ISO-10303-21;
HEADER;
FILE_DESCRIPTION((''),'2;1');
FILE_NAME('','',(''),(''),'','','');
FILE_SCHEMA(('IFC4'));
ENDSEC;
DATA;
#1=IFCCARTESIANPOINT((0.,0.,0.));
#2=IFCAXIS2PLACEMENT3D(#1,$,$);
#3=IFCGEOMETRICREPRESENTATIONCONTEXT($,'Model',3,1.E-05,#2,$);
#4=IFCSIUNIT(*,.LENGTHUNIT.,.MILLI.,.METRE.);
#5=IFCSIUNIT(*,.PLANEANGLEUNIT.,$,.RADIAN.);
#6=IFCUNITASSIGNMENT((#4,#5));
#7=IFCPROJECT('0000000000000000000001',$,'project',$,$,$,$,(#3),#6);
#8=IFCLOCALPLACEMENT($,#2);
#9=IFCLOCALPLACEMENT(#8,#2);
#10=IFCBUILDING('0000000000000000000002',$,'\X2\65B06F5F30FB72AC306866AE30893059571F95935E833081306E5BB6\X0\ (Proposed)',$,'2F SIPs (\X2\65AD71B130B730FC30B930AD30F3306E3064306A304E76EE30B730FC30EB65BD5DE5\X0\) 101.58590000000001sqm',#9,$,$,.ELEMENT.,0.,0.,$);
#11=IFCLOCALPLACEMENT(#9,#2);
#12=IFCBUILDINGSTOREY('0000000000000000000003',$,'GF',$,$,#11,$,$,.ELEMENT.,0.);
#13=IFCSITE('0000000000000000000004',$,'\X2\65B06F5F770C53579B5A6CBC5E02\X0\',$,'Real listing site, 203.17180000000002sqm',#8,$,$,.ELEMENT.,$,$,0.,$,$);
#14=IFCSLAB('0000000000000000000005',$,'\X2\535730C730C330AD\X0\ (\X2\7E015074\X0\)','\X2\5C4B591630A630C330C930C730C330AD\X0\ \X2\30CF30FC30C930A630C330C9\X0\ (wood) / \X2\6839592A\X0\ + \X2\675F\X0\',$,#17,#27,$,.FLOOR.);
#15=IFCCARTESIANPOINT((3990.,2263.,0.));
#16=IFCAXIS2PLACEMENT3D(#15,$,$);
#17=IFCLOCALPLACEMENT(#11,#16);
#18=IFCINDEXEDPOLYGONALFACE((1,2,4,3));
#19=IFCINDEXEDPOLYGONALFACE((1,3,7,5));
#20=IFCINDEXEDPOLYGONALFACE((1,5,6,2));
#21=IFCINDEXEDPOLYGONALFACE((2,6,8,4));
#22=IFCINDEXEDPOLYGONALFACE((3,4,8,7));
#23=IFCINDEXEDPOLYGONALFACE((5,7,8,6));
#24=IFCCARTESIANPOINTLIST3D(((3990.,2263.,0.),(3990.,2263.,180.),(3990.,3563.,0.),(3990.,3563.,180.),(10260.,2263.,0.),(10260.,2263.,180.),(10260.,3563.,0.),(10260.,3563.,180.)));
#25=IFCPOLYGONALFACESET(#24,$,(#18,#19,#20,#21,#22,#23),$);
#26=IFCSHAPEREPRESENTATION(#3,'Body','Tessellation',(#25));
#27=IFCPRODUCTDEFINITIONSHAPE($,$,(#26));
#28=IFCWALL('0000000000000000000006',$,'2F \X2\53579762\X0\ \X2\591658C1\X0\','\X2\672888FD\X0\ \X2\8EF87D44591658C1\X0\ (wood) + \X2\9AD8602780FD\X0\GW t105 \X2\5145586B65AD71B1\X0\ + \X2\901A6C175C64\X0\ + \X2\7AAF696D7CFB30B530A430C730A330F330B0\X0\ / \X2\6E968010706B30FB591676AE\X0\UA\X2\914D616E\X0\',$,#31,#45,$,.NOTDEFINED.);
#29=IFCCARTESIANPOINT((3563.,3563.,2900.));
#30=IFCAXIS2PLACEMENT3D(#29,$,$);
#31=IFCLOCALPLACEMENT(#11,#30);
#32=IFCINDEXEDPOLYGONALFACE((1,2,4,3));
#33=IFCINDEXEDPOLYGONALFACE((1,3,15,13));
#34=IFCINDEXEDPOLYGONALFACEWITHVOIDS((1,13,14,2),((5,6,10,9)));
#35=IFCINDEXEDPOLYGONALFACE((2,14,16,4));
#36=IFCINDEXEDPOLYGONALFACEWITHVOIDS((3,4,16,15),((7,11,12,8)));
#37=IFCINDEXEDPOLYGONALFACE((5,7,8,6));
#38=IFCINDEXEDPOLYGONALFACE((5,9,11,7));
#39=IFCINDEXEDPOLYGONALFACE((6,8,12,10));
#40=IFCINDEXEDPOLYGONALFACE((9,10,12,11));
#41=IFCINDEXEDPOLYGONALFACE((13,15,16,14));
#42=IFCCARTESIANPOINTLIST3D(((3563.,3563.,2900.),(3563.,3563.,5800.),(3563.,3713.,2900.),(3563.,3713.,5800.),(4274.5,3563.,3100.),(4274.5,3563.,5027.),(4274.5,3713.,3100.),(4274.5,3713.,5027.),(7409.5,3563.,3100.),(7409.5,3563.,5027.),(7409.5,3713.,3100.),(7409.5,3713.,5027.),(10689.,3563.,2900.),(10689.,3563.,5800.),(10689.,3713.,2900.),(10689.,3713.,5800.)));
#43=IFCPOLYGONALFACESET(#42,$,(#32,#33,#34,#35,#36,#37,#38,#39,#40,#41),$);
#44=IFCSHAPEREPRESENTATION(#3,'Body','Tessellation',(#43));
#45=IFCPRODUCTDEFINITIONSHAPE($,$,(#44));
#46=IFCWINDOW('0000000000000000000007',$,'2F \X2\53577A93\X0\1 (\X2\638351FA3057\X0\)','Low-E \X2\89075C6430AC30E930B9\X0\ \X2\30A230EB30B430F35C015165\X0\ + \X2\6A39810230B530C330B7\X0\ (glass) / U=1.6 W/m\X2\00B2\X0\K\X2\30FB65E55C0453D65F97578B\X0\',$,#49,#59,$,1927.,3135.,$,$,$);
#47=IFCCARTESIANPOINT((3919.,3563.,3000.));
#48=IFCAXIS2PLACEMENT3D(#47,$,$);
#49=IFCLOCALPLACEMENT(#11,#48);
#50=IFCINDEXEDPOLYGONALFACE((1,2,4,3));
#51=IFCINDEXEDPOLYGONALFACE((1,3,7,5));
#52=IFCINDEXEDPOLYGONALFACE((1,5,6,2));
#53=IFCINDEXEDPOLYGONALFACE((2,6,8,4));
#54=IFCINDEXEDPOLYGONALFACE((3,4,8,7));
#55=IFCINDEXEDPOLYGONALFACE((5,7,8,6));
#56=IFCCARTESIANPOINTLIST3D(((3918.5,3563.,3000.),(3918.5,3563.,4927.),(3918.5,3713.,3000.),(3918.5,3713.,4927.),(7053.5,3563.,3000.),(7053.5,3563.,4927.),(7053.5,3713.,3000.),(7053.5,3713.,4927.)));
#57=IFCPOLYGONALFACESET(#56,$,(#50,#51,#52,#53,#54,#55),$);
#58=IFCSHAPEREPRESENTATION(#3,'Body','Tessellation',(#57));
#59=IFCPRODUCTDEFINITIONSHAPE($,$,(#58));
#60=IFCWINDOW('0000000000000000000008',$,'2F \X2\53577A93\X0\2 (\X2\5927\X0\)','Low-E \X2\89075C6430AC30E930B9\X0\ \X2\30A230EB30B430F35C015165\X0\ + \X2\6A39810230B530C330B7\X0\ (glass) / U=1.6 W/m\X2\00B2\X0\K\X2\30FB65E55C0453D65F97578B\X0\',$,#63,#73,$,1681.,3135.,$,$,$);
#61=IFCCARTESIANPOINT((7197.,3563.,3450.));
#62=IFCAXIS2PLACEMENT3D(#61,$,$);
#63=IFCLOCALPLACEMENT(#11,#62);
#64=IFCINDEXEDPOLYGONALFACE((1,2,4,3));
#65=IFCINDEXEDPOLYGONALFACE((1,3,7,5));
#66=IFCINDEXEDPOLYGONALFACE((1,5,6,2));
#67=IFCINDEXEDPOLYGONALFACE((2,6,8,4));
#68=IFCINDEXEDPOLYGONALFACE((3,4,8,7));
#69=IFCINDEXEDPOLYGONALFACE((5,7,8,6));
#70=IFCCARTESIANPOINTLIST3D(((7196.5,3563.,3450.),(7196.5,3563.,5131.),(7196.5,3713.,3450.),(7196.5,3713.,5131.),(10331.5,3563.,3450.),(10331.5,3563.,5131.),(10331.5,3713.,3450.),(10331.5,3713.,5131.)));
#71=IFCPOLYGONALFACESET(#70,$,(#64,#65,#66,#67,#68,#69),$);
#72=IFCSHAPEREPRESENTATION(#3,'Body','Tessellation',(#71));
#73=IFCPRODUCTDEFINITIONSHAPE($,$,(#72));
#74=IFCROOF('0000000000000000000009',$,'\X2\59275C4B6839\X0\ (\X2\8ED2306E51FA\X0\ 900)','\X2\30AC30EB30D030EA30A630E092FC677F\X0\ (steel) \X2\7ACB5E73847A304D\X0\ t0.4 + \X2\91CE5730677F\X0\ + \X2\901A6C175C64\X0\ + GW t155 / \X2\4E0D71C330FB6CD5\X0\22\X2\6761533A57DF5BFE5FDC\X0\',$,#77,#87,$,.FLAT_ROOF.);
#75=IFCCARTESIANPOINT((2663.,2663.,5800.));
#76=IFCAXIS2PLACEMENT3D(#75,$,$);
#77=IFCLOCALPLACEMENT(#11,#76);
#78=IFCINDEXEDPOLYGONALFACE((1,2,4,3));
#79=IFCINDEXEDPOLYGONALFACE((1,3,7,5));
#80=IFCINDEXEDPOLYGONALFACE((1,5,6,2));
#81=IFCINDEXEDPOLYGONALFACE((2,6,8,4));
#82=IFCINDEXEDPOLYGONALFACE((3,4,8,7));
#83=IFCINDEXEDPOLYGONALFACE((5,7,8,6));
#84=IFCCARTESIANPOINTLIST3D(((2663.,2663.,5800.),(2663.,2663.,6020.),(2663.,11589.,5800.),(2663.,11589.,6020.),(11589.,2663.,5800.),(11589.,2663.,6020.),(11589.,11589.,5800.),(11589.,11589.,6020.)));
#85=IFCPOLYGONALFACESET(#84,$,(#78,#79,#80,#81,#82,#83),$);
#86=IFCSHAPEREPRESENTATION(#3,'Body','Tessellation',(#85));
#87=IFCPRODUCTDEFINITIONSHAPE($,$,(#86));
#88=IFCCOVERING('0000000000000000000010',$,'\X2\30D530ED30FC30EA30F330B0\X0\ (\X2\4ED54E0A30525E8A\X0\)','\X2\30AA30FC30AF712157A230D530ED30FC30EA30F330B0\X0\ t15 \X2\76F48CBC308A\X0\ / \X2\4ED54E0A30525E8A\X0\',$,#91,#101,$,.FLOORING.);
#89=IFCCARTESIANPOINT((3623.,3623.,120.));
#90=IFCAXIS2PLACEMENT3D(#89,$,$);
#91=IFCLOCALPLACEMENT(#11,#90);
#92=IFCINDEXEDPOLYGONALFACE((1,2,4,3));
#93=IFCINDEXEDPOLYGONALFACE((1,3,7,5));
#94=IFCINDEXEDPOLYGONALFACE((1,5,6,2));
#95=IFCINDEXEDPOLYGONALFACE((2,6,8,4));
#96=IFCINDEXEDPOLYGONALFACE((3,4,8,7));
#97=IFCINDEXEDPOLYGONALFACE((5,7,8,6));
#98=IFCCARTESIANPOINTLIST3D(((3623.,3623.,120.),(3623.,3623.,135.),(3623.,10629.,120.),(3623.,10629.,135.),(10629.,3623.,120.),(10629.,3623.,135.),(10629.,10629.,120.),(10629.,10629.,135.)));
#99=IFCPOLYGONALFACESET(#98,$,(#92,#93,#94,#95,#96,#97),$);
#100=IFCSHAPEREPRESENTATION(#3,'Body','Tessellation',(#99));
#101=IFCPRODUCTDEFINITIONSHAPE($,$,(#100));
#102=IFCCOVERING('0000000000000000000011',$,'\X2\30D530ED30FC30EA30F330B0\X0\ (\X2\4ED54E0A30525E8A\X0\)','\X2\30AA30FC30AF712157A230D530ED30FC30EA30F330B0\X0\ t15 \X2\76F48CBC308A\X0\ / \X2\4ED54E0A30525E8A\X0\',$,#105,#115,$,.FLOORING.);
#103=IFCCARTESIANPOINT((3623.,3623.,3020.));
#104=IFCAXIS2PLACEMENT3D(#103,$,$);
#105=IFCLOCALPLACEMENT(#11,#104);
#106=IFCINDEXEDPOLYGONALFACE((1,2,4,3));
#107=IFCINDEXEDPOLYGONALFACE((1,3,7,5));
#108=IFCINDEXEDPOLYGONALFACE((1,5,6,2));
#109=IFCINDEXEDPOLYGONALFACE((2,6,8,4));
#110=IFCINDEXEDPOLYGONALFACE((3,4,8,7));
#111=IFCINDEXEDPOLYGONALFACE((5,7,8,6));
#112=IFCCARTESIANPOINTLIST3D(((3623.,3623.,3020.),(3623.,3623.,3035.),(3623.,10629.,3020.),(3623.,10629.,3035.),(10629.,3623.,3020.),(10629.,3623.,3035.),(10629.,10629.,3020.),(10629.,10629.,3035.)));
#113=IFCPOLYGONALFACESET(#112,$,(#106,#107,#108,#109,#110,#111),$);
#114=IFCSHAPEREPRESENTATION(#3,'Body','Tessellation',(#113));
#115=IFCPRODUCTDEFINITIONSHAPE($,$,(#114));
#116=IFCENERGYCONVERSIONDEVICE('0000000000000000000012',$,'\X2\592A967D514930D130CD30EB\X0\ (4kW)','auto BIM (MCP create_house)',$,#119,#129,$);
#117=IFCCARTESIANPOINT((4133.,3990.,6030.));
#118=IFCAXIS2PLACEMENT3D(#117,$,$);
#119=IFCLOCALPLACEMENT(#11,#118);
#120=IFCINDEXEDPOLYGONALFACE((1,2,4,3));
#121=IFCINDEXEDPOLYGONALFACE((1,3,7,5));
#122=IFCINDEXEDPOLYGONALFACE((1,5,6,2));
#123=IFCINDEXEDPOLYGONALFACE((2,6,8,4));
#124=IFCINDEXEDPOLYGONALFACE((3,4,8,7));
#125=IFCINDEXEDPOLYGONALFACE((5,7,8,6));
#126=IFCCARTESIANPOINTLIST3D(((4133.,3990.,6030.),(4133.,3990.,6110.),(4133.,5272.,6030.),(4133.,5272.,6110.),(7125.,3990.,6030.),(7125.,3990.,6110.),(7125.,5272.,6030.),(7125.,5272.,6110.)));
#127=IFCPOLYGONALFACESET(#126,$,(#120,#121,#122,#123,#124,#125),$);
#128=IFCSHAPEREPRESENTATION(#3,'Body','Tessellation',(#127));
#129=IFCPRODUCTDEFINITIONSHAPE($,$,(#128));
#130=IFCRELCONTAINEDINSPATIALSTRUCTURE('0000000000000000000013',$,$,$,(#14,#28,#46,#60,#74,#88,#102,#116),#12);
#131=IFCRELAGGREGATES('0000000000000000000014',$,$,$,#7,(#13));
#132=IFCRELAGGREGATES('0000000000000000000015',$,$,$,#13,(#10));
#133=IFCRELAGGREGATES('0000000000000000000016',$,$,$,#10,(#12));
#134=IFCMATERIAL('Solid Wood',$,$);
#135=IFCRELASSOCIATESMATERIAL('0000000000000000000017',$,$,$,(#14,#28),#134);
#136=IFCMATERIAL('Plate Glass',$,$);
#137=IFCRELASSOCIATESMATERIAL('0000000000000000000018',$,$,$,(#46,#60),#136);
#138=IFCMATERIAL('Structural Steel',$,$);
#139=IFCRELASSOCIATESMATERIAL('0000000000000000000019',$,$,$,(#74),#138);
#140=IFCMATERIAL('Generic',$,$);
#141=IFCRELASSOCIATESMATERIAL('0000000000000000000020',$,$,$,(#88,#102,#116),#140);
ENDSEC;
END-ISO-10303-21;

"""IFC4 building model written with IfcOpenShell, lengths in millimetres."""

from ifc_helpers import new_model, si_unit, frame, frame_2d, origin, place, context, project, spatial, rectangle, extrude, material, element, fill, save


model = new_model("IFC4")

# Units and contexts
model_context = context("Model", 3, precision=1e-05, world=origin())
ifc_project = project(units=[si_unit("LENGTHUNIT", "METRE", prefix="MILLI"), si_unit("PLANEANGLEUNIT", "RADIAN")], contexts=[model_context])

# Site, building, storey
site_placement = place(None, origin())
site = spatial("IfcSite", under=ifc_project, at=site_placement, Name="新潟県南魚沼市", ObjectType="Real listing site, 203.17180000000002sqm", CompositionType="ELEMENT", RefElevation=0.0)
building_placement = place(site_placement, origin())
building = spatial("IfcBuilding", under=site, at=building_placement, Name="新潟・犬と暮らす土間広めの家 (Proposed)", ObjectType="2F SIPs (断熱シースキンのつなぎ目シール施工) 101.58590000000001sqm", CompositionType="ELEMENT", ElevationOfRefHeight=0.0, ElevationOfTerrain=0.0)
storey_placement = place(building_placement, origin())
storey = spatial("IfcBuildingStorey", under=building, at=storey_placement, Name="GF", CompositionType="ELEMENT", Elevation=0.0)

# Slab
ifc_material_1 = material(Name="Solid Wood")
slab_1_placement = place(storey_placement, frame((3990.0, 2263.0, 0.0)))
element("IfcSlab", 1, at=slab_1_placement, inside=storey, material=ifc_material_1, Name="南デッキ (縁側)", Description="屋外ウッドデッキ ハードウッド (wood) / 根太 + 束", PredefinedType="FLOOR", context=model_context, shape_type="SweptSolid", body=[
    extrude(rectangle(XDim=6270.0, YDim=1300.0, at=frame_2d((3135.0, 650.0))), frame((3990.0, 2263.0, 0.0)), (0.0, 0.0, 1.0), 180.0),
])

# Shared definitions
ifc_material_2 = material(Name="Plate Glass")

# Wall, openings, windows
wall_1_placement = place(storey_placement, frame((3563.0, 3563.0, 2900.0)))
wall_1 = element("IfcWall", 2, at=wall_1_placement, inside=storey, material=ifc_material_1, Name="2F 南面 外壁", Description="木製 軸組外壁 (wood) + 高性能GW t105 充填断熱 + 通気層 + 窯業系サイディング / 準耐火・外皮UA配慮", PredefinedType="NOTDEFINED", context=model_context, shape_type="SweptSolid", body=[
    extrude(rectangle(XDim=7126.0, YDim=150.0, at=frame_2d((3563.0, 75.0))), frame((3563.0, 3563.0, 2900.0)), (0.0, 0.0, 1.0), 2900.0),
])
opening_1_placement = place(storey_placement, frame((3919.0, 3563.0, 3000.0)))
opening_1 = element("IfcOpeningElement", 3, at=opening_1_placement, cuts=wall_1, PredefinedType="NOTDEFINED", context=model_context, shape_type="SweptSolid", body=[
    extrude(rectangle(XDim=3135.0, YDim=150.0, at=frame_2d((1567.0, 75.0))), frame((3919.0, 3563.0, 3000.0)), (0.0, 0.0, 1.0), 1927.0),
])
opening_2_placement = place(storey_placement, frame((7197.0, 3563.0, 3450.0)))
opening_2 = element("IfcOpeningElement", 4, at=opening_2_placement, cuts=wall_1, PredefinedType="NOTDEFINED", context=model_context, shape_type="SweptSolid", body=[
    extrude(rectangle(XDim=3135.0, YDim=150.0, at=frame_2d((1567.0, 75.0))), frame((7197.0, 3563.0, 3450.0)), (0.0, 0.0, 1.0), 1681.0),
])
window_1_placement = place(storey_placement, frame((3919.0, 3563.0, 3000.0)))
window_1 = element("IfcWindow", 5, at=window_1_placement, inside=storey, material=ifc_material_2, Name="2F 南窓1 (掃出し)", Description="Low-E 複層ガラス アルゴン封入 + 樹脂サッシ (glass) / U=1.6 W/m²K・日射取得型", OverallHeight=1927.0, OverallWidth=3135.0, context=model_context, shape_type="SweptSolid", body=[
    extrude(rectangle(XDim=3135.0, YDim=150.0, at=frame_2d((1567.0, 75.0))), frame((3919.0, 3563.0, 3000.0)), (0.0, 0.0, 1.0), 1927.0),
])
fill(opening_1, window_1)
window_2_placement = place(storey_placement, frame((7197.0, 3563.0, 3450.0)))
window_2 = element("IfcWindow", 6, at=window_2_placement, inside=storey, material=ifc_material_2, Name="2F 南窓2 (大)", Description="Low-E 複層ガラス アルゴン封入 + 樹脂サッシ (glass) / U=1.6 W/m²K・日射取得型", OverallHeight=1681.0, OverallWidth=3135.0, context=model_context, shape_type="SweptSolid", body=[
    extrude(rectangle(XDim=3135.0, YDim=150.0, at=frame_2d((1567.0, 75.0))), frame((7197.0, 3563.0, 3450.0)), (0.0, 0.0, 1.0), 1681.0),
])
fill(opening_2, window_2)

# Roof
ifc_material_3 = material(Name="Structural Steel")
roof_placement = place(storey_placement, frame((2663.0, 2663.0, 5800.0)))
element("IfcRoof", 7, at=roof_placement, inside=storey, material=ifc_material_3, Name="大屋根 (軒の出 900)", Description="ガルバリウム鋼板 (steel) 立平葺き t0.4 + 野地板 + 通気層 + GW t155 / 不燃・法22条区域対応", PredefinedType="FLAT_ROOF", context=model_context, shape_type="SweptSolid", body=[
    extrude(rectangle(XDim=8926.0, YDim=8926.0, at=frame_2d((4463.0, 4463.0))), frame((2663.0, 2663.0, 5800.0)), (0.0, 0.0, 1.0), 220.0),
])

# Coverings
ifc_material_4 = material(Name="Generic")
covering_1_placement = place(storey_placement, frame((3623.0, 3623.0, 120.0)))
element("IfcCovering", 8, at=covering_1_placement, inside=storey, material=ifc_material_4, Name="フローリング (仕上げ床)", Description="オーク無垢フローリング t15 直貼り / 仕上げ床", PredefinedType="FLOORING", context=model_context, shape_type="SweptSolid", body=[
    extrude(rectangle(XDim=7006.0, YDim=7006.0, at=frame_2d((3503.0, 3503.0))), frame((3623.0, 3623.0, 120.0)), (0.0, 0.0, 1.0), 15.0),
])
covering_2_placement = place(storey_placement, frame((3623.0, 3623.0, 3020.0)))
element("IfcCovering", 9, at=covering_2_placement, inside=storey, material=ifc_material_4, Name="フローリング (仕上げ床)", Description="オーク無垢フローリング t15 直貼り / 仕上げ床", PredefinedType="FLOORING", context=model_context, shape_type="SweptSolid", body=[
    extrude(rectangle(XDim=7006.0, YDim=7006.0, at=frame_2d((3503.0, 3503.0))), frame((3623.0, 3623.0, 3020.0)), (0.0, 0.0, 1.0), 15.0),
])

# Energy conversion device
energy_conversion_device_placement = place(storey_placement, frame((4133.0, 3990.0, 6030.0)))
element("IfcEnergyConversionDevice", 10, at=energy_conversion_device_placement, inside=storey, material=ifc_material_4, Name="太陽光パネル (4kW)", Description="auto BIM (MCP create_house)", context=model_context, shape_type="SweptSolid", body=[
    extrude(rectangle(XDim=2992.0, YDim=1282.0, at=frame_2d((1496.0, 641.0))), frame((4133.0, 3990.0, 6030.0)), (0.0, 0.0, 1.0), 80.0),
])

save(model, "model.ifc")
